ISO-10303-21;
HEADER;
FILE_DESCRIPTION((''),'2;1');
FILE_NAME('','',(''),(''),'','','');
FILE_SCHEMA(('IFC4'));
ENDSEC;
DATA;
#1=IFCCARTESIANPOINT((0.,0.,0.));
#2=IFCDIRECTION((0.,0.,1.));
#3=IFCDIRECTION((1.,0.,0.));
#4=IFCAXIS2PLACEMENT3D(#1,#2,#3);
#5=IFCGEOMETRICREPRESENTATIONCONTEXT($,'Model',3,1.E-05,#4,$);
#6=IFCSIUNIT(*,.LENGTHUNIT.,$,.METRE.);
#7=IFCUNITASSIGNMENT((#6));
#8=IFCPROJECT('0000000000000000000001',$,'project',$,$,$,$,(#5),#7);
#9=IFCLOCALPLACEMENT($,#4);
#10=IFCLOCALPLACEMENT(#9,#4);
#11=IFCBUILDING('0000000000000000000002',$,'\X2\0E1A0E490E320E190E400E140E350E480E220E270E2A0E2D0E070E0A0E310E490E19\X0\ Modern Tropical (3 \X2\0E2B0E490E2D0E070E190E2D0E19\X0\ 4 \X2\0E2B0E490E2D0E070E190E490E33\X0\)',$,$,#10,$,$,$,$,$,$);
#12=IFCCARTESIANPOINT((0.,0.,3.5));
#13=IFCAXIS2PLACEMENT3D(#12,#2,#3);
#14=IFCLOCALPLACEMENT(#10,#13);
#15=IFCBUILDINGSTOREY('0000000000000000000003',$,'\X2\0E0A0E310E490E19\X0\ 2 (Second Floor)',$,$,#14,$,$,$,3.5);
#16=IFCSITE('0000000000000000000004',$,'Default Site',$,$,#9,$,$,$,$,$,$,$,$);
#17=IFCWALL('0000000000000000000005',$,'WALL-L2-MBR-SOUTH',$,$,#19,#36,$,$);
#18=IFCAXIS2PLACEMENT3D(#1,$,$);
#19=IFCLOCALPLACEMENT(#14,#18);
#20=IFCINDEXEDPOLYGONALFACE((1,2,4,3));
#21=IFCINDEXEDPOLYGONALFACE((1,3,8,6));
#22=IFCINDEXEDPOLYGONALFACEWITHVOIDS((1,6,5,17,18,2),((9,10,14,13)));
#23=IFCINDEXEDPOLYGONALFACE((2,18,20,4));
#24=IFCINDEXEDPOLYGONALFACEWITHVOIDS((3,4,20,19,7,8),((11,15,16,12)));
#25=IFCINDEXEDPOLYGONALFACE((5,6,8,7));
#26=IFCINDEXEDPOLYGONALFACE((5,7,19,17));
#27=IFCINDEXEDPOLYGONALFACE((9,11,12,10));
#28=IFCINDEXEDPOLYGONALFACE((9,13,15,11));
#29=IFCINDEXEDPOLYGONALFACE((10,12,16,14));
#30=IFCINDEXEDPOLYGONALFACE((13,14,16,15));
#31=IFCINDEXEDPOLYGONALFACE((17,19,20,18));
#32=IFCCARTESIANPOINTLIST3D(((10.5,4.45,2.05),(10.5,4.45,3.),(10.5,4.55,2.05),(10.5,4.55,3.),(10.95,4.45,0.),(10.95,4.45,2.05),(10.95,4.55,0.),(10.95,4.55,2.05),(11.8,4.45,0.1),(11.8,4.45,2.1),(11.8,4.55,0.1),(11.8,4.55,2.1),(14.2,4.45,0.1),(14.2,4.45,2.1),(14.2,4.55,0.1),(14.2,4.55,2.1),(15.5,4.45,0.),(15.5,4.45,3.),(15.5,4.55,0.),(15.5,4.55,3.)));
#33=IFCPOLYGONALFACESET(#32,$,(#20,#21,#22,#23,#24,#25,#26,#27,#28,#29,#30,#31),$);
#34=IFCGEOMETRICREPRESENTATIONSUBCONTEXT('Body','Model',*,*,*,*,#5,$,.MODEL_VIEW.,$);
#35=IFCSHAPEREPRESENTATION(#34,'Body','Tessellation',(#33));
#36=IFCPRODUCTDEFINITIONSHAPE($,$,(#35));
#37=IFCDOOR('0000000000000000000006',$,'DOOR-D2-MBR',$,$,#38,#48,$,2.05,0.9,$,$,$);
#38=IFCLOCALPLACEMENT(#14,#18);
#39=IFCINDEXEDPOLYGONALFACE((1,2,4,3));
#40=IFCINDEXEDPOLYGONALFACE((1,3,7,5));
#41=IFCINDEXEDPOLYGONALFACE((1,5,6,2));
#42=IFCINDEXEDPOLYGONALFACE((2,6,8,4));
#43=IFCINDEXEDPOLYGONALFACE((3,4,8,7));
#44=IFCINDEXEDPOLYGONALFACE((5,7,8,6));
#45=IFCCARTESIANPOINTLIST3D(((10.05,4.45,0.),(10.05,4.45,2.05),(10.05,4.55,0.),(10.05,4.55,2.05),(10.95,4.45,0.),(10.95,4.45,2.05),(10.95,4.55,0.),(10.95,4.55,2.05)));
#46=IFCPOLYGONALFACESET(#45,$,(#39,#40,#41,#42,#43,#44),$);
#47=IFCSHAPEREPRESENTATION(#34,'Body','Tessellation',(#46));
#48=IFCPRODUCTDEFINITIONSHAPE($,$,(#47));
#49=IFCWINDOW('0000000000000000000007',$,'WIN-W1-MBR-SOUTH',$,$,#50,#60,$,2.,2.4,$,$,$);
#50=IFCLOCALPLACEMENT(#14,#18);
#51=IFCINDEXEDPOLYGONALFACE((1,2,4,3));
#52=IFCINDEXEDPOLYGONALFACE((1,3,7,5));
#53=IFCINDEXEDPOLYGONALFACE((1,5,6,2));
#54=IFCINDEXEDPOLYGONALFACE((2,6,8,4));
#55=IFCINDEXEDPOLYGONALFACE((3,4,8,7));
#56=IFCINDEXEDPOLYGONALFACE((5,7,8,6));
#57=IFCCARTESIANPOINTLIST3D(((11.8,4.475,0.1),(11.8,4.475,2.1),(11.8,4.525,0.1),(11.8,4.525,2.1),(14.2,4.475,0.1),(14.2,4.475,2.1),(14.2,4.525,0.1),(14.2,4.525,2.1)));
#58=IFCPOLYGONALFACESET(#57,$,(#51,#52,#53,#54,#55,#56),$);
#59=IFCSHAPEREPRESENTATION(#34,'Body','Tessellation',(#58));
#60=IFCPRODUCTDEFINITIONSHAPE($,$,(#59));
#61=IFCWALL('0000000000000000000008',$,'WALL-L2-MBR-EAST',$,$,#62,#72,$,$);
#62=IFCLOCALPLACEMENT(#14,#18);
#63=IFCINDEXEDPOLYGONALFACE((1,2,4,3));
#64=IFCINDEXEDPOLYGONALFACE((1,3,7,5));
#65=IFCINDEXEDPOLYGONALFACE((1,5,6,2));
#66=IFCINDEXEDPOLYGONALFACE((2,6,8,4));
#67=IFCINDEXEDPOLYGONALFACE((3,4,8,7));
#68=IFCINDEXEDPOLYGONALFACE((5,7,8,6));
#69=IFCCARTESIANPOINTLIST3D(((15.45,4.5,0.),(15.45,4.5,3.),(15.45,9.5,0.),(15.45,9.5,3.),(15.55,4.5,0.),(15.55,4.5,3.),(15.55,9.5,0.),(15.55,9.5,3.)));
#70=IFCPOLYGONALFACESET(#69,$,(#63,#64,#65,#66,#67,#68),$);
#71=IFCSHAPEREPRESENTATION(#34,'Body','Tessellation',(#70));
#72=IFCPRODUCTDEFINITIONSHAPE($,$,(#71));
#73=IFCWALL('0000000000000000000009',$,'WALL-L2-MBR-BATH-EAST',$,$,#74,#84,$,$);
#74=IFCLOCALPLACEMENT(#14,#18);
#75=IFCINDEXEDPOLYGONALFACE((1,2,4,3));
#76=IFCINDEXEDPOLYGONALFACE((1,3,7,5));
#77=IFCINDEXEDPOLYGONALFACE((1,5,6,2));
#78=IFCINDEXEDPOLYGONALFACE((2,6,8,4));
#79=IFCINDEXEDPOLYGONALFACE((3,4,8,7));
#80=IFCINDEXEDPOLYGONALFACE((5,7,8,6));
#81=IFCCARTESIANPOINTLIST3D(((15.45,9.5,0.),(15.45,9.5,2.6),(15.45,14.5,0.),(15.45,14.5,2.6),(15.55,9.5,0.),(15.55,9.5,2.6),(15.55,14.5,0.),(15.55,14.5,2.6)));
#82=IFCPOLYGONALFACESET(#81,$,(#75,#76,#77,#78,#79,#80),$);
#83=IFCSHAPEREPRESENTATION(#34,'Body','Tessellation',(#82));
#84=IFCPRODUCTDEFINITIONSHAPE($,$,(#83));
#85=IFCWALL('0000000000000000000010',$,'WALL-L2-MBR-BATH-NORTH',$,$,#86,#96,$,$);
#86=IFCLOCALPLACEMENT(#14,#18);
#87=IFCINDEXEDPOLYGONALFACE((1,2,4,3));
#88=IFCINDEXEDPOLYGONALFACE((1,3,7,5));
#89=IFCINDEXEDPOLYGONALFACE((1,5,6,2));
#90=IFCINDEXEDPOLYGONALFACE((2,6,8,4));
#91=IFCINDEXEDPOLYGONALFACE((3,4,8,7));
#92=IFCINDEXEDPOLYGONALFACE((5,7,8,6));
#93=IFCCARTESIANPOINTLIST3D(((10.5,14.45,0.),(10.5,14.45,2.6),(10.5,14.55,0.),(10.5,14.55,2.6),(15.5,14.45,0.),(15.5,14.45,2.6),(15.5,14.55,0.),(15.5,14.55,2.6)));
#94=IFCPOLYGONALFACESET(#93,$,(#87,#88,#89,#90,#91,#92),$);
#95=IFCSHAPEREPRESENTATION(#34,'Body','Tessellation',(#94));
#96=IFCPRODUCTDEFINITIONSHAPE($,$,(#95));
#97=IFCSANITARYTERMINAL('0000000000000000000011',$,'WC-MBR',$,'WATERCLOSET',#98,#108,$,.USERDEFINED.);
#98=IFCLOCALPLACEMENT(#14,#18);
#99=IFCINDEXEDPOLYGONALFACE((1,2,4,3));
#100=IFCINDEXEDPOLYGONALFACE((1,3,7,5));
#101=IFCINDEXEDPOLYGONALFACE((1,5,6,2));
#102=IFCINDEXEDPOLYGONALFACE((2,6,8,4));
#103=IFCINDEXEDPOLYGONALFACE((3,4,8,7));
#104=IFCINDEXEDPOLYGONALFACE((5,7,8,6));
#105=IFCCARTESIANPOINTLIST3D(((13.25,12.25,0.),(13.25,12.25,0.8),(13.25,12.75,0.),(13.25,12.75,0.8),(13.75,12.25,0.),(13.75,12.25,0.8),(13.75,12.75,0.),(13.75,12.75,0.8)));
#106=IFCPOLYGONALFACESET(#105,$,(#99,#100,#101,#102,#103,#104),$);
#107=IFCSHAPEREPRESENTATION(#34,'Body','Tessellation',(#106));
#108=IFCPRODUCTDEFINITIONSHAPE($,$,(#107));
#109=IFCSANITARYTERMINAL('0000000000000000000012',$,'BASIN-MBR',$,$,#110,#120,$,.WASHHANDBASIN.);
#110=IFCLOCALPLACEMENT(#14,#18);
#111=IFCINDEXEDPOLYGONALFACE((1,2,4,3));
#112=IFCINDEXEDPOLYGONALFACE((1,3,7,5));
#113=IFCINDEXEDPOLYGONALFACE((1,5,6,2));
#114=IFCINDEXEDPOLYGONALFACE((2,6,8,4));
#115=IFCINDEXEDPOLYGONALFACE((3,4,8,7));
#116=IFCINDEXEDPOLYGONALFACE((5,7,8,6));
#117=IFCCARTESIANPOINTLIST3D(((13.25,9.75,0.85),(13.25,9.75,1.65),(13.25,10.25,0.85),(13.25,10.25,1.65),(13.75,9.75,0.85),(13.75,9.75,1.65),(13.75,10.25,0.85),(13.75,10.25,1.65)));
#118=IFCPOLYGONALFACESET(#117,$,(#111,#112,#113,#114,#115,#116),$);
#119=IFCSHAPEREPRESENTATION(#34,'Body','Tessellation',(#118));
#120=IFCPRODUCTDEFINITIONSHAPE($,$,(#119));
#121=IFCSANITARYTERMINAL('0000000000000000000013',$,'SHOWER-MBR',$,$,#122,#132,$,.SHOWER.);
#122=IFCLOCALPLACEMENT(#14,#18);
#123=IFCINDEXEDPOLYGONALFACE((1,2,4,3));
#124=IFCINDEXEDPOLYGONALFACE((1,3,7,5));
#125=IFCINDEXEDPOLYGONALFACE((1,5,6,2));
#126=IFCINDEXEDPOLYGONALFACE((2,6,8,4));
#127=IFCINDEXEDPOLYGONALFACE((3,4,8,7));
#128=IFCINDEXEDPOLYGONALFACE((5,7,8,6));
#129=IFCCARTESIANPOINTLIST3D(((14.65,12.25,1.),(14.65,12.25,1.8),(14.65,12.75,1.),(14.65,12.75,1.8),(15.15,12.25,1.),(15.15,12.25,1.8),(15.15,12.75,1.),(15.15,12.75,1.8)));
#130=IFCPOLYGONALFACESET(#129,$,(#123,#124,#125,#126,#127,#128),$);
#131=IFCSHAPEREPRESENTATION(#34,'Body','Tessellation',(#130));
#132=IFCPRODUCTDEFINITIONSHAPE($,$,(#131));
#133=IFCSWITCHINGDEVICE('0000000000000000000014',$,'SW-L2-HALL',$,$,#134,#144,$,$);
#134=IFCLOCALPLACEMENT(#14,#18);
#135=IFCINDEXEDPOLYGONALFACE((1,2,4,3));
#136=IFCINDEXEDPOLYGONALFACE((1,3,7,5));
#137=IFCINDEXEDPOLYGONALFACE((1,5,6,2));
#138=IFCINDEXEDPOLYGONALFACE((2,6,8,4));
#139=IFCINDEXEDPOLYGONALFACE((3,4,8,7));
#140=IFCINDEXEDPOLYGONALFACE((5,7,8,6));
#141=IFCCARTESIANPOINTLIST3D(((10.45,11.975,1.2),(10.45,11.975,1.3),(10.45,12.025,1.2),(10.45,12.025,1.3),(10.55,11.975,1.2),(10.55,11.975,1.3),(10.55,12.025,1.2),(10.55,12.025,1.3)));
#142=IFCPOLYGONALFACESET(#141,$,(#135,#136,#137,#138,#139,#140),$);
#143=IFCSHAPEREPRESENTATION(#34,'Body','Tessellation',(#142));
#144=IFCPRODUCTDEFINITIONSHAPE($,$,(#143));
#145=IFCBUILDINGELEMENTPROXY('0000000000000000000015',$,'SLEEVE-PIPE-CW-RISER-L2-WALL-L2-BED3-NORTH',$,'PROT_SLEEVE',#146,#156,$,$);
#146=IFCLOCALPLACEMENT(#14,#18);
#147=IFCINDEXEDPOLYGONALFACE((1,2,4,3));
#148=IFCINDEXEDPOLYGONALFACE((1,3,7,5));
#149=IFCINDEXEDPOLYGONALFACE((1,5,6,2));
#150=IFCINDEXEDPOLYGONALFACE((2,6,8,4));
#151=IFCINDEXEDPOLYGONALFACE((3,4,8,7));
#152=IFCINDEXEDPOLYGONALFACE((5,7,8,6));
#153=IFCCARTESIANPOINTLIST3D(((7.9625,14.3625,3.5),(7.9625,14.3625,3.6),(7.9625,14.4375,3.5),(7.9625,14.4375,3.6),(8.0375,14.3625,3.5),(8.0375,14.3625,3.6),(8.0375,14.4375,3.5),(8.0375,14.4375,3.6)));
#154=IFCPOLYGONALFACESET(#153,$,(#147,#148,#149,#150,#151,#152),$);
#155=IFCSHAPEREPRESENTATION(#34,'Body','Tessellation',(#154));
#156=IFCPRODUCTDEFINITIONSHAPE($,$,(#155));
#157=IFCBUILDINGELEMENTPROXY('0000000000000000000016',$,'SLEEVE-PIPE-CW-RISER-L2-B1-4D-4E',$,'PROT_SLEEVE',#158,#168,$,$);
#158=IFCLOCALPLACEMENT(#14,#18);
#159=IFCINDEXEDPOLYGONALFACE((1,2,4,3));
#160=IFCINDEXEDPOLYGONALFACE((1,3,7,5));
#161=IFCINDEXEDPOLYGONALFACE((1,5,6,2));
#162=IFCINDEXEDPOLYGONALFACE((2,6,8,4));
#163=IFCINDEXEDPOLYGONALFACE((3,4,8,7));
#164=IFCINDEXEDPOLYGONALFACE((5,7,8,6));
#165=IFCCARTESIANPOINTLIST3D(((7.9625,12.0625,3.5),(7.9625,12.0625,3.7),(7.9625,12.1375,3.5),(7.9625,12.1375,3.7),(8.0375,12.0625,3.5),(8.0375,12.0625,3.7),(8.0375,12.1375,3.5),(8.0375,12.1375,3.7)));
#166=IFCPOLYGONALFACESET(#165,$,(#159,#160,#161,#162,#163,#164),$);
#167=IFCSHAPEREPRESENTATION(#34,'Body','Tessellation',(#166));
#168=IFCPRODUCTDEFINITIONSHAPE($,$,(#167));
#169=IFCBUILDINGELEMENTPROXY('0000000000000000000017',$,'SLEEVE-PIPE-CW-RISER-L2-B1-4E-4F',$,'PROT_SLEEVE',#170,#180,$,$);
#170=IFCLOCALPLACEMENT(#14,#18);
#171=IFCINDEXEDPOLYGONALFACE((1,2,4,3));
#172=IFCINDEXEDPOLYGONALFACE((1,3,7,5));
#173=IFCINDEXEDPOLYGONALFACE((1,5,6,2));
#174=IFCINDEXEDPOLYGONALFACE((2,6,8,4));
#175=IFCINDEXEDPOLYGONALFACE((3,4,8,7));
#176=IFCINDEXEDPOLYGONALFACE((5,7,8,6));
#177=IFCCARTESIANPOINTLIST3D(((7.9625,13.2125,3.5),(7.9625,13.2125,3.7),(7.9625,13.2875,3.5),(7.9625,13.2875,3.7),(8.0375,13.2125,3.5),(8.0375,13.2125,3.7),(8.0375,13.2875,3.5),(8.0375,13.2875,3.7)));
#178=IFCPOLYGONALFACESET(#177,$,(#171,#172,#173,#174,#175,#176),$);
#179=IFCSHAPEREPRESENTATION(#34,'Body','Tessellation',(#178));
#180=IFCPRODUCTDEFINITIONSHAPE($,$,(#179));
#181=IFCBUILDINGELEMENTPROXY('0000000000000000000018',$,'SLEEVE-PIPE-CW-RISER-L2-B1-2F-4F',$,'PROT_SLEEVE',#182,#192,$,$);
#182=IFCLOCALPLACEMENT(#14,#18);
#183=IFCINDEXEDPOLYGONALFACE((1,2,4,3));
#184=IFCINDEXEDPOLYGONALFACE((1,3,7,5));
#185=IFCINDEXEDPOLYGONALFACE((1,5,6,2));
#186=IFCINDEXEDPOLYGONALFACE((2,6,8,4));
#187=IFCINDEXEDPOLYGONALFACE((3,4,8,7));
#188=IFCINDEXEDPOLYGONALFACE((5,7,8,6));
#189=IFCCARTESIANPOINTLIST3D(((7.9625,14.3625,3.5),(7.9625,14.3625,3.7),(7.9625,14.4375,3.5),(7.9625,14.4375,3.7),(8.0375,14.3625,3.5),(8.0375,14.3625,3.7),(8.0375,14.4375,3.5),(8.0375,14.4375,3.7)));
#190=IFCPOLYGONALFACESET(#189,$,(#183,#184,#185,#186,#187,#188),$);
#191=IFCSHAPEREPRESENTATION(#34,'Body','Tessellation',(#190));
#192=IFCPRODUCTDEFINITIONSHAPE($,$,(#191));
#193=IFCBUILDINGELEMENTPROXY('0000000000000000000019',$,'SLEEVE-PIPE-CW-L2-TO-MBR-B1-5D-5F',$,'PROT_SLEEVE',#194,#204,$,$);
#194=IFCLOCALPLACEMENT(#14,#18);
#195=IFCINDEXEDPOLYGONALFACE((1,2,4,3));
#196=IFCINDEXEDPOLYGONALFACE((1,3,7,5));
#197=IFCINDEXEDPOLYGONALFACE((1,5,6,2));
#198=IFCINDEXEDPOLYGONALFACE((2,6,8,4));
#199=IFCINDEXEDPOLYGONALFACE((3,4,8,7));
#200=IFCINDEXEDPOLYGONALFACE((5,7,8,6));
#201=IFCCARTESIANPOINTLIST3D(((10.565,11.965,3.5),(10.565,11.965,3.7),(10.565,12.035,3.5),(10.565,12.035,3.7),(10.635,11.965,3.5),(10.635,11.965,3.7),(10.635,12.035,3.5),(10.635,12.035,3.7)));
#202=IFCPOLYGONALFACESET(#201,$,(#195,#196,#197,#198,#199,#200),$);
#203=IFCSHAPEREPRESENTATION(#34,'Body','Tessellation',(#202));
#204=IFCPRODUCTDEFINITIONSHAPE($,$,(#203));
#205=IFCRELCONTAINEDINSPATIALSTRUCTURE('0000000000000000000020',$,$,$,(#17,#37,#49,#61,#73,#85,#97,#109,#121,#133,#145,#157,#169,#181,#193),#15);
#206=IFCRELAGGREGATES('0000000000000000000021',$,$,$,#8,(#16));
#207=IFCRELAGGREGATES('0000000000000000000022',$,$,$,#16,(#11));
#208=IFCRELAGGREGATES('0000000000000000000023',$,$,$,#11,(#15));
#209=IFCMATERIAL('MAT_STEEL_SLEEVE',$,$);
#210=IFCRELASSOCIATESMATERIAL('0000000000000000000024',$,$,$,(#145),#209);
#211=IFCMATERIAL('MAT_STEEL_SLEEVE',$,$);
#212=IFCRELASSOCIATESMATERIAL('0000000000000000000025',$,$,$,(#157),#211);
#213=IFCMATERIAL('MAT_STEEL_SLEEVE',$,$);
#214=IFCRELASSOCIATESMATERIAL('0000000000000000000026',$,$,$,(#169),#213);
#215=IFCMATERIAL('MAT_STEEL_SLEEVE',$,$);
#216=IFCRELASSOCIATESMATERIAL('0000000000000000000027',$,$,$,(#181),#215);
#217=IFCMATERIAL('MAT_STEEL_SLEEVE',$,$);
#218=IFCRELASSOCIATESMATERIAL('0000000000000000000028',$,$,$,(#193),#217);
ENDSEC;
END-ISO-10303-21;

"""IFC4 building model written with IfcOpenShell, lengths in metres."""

from ifc_helpers import new_model, si_unit, frame, origin_with_axes, origin_2d, place, context, subcontext, project, spatial, rectangle, extrude, material, element, fill, save


model = new_model("IFC4")

# Units and contexts
model_context = context("Model", 3, precision=1e-05, world=origin_with_axes())
body_context = subcontext(model_context, "Body", "Model", "MODEL_VIEW")
ifc_project = project(units=[si_unit("LENGTHUNIT", "METRE")], contexts=[model_context])

# Site, building, storey
site_placement = place(None, origin_with_axes())
site = spatial("IfcSite", under=ifc_project, at=site_placement, Name="Default Site")
building_placement = place(site_placement, origin_with_axes())
building = spatial("IfcBuilding", under=site, at=building_placement, Name="บ้านเดี่ยวสองชั้น Modern Tropical (3 ห้องนอน 4 ห้องน้ำ)")
storey_placement = place(building_placement, frame((0.0, 0.0, 3.5), z_axis=(0.0, 0.0, 1.0), x_axis=(1.0, 0.0, 0.0)))
storey = spatial("IfcBuildingStorey", under=building, at=storey_placement, Name="ชั้น 2 (Second Floor)", Elevation=3.5)

# Wall, openings, door, window
wall_1_placement = place(storey_placement, frame((13.0, 4.5, 0.0), z_axis=(0.0, 0.0, 1.0), x_axis=(1.0, 0.0, 0.0)))
wall_1 = element("IfcWall", 1, at=wall_1_placement, inside=storey, Name="WALL-L2-MBR-SOUTH", context=body_context, shape_type="SweptSolid", body=[
    extrude(rectangle(XDim=5.0, YDim=0.1, at=origin_2d()), origin_with_axes(), (0.0, 0.0, 1.0), 3.0),
])
opening_1_placement = place(wall_1_placement, frame((-2.5, 0.0, 0.0), z_axis=(0.0, 0.0, 1.0), x_axis=(1.0, 0.0, 0.0)))
opening_1 = element("IfcOpeningElement", 2, at=opening_1_placement, cuts=wall_1, context=body_context, shape_type="SweptSolid", body=[
    extrude(rectangle(XDim=0.9, YDim=0.12, at=origin_2d()), origin_with_axes(), (0.0, 0.0, 1.0), 2.05),
])
opening_2_placement = place(wall_1_placement, frame((0.0, 0.0, 0.1), z_axis=(0.0, 0.0, 1.0), x_axis=(1.0, 0.0, 0.0)))
opening_2 = element("IfcOpeningElement", 3, at=opening_2_placement, cuts=wall_1, context=body_context, shape_type="SweptSolid", body=[
    extrude(rectangle(XDim=2.4, YDim=0.12, at=origin_2d()), origin_with_axes(), (0.0, 0.0, 1.0), 2.0),
])
door_placement = place(opening_1_placement, origin_with_axes())
door = element("IfcDoor", 4, at=door_placement, inside=storey, Name="DOOR-D2-MBR", OverallHeight=2.05, OverallWidth=0.9, context=body_context, shape_type="SweptSolid", body=[
    extrude(rectangle(XDim=0.9, YDim=0.1, at=origin_2d()), origin_with_axes(), (0.0, 0.0, 1.0), 2.05),
])
fill(opening_1, door)
window_placement = place(opening_2_placement, origin_with_axes())
window = element("IfcWindow", 5, at=window_placement, inside=storey, Name="WIN-W1-MBR-SOUTH", OverallHeight=2.0, OverallWidth=2.4, context=body_context, shape_type="SweptSolid", body=[
    extrude(rectangle(XDim=2.4, YDim=0.05, at=origin_2d()), origin_with_axes(), (0.0, 0.0, 1.0), 2.0),
])
fill(opening_2, window)

# Walls
wall_2_placement = place(storey_placement, frame((15.5, 7.0, 0.0), z_axis=(0.0, 0.0, 1.0), x_axis=(0.0, 1.0, 0.0)))
element("IfcWall", 6, at=wall_2_placement, inside=storey, Name="WALL-L2-MBR-EAST", context=body_context, shape_type="SweptSolid", body=[
    extrude(rectangle(XDim=5.0, YDim=0.1, at=origin_2d()), origin_with_axes(), (0.0, 0.0, 1.0), 3.0),
])
for number, where, z_axis, x_axis, name in (
    (7, (15.5, 12.0, 0.0), (0.0, 0.0, 1.0), (0.0, 1.0, 0.0), "WALL-L2-MBR-BATH-EAST"),
    (8, (13.0, 14.5, 0.0), (0.0, 0.0, 1.0), (1.0, 0.0, 0.0), "WALL-L2-MBR-BATH-NORTH"),
):
    element("IfcWall", number, at=place(storey_placement, frame(where, z_axis=z_axis, x_axis=x_axis)), inside=storey, Name=name, context=body_context, shape_type="SweptSolid", body=[
        extrude(rectangle(XDim=5.0, YDim=0.1, at=origin_2d()), origin_with_axes(), (0.0, 0.0, 1.0), 2.6),
    ])

# Sanitary terminals
sanitary_terminal_1_placement = place(storey_placement, frame((13.5, 12.5, 0.0), z_axis=(0.0, 0.0, 1.0), x_axis=(1.0, 0.0, 0.0)))
element("IfcSanitaryTerminal", 9, at=sanitary_terminal_1_placement, inside=storey, Name="WC-MBR", ObjectType="WATERCLOSET", PredefinedType="USERDEFINED", context=body_context, shape_type="SweptSolid", body=[
    extrude(rectangle(XDim=0.5, YDim=0.5, at=origin_2d()), origin_with_axes(), (0.0, 0.0, 1.0), 0.8),
])
sanitary_terminal_2_placement = place(storey_placement, frame((13.5, 10.0, 0.85), z_axis=(0.0, 0.0, 1.0), x_axis=(1.0, 0.0, 0.0)))
element("IfcSanitaryTerminal", 10, at=sanitary_terminal_2_placement, inside=storey, Name="BASIN-MBR", PredefinedType="WASHHANDBASIN", context=body_context, shape_type="SweptSolid", body=[
    extrude(rectangle(XDim=0.5, YDim=0.5, at=origin_2d()), origin_with_axes(), (0.0, 0.0, 1.0), 0.8),
])
sanitary_terminal_3_placement = place(storey_placement, frame((14.9, 12.5, 1.0), z_axis=(0.0, 0.0, 1.0), x_axis=(1.0, 0.0, 0.0)))
element("IfcSanitaryTerminal", 11, at=sanitary_terminal_3_placement, inside=storey, Name="SHOWER-MBR", PredefinedType="SHOWER", context=body_context, shape_type="SweptSolid", body=[
    extrude(rectangle(XDim=0.5, YDim=0.5, at=origin_2d()), origin_with_axes(), (0.0, 0.0, 1.0), 0.8),
])

# Switching device
switching_device_placement = place(storey_placement, frame((10.5, 12.0, 1.2), z_axis=(0.0, 0.0, 1.0), x_axis=(1.0, 0.0, 0.0)))
element("IfcSwitchingDevice", 12, at=switching_device_placement, inside=storey, Name="SW-L2-HALL", context=body_context, shape_type="SweptSolid", body=[
    extrude(rectangle(XDim=0.1, YDim=0.05, at=origin_2d()), origin_with_axes(), (0.0, 0.0, 1.0), 0.1),
])

# Building element proxies
ifc_material_1 = material(Name="MAT_STEEL_SLEEVE")
proxy_1_placement = place(storey_placement, frame((8.0, 14.4, 3.5), z_axis=(0.0, 0.0, 1.0), x_axis=(1.0, 0.0, 0.0)))
element("IfcBuildingElementProxy", 13, at=proxy_1_placement, inside=storey, material=ifc_material_1, Name="SLEEVE-PIPE-CW-RISER-L2-WALL-L2-BED3-NORTH", ObjectType="PROT_SLEEVE", context=body_context, shape_type="SweptSolid", body=[
    extrude(rectangle(XDim=0.075, YDim=0.075, at=origin_2d()), origin_with_axes(), (0.0, 0.0, 1.0), 0.1),
])
ifc_material_2 = material(Name="MAT_STEEL_SLEEVE")
proxy_2_placement = place(storey_placement, frame((8.0, 12.1, 3.5), z_axis=(0.0, 0.0, 1.0), x_axis=(1.0, 0.0, 0.0)))
element("IfcBuildingElementProxy", 14, at=proxy_2_placement, inside=storey, material=ifc_material_2, Name="SLEEVE-PIPE-CW-RISER-L2-B1-4D-4E", ObjectType="PROT_SLEEVE", context=body_context, shape_type="SweptSolid", body=[
    extrude(rectangle(XDim=0.075, YDim=0.075, at=origin_2d()), origin_with_axes(), (0.0, 0.0, 1.0), 0.2),
])
ifc_material_3 = material(Name="MAT_STEEL_SLEEVE")
proxy_3_placement = place(storey_placement, frame((8.0, 13.25, 3.5), z_axis=(0.0, 0.0, 1.0), x_axis=(1.0, 0.0, 0.0)))
element("IfcBuildingElementProxy", 15, at=proxy_3_placement, inside=storey, material=ifc_material_3, Name="SLEEVE-PIPE-CW-RISER-L2-B1-4E-4F", ObjectType="PROT_SLEEVE", context=body_context, shape_type="SweptSolid", body=[
    extrude(rectangle(XDim=0.075, YDim=0.075, at=origin_2d()), origin_with_axes(), (0.0, 0.0, 1.0), 0.2),
])
ifc_material_4 = material(Name="MAT_STEEL_SLEEVE")
proxy_4_placement = place(storey_placement, frame((8.0, 14.4, 3.5), z_axis=(0.0, 0.0, 1.0), x_axis=(1.0, 0.0, 0.0)))
element("IfcBuildingElementProxy", 16, at=proxy_4_placement, inside=storey, material=ifc_material_4, Name="SLEEVE-PIPE-CW-RISER-L2-B1-2F-4F", ObjectType="PROT_SLEEVE", context=body_context, shape_type="SweptSolid", body=[
    extrude(rectangle(XDim=0.075, YDim=0.075, at=origin_2d()), origin_with_axes(), (0.0, 0.0, 1.0), 0.2),
])
ifc_material_5 = material(Name="MAT_STEEL_SLEEVE")
proxy_5_placement = place(storey_placement, frame((10.6, 12.0, 3.5), z_axis=(0.0, 0.0, 1.0), x_axis=(1.0, 0.0, 0.0)))
element("IfcBuildingElementProxy", 17, at=proxy_5_placement, inside=storey, material=ifc_material_5, Name="SLEEVE-PIPE-CW-L2-TO-MBR-B1-5D-5F", ObjectType="PROT_SLEEVE", context=body_context, shape_type="SweptSolid", body=[
    extrude(rectangle(XDim=0.07, YDim=0.07, at=origin_2d()), origin_with_axes(), (0.0, 0.0, 1.0), 0.2),
])

save(model, "model.ifc")
